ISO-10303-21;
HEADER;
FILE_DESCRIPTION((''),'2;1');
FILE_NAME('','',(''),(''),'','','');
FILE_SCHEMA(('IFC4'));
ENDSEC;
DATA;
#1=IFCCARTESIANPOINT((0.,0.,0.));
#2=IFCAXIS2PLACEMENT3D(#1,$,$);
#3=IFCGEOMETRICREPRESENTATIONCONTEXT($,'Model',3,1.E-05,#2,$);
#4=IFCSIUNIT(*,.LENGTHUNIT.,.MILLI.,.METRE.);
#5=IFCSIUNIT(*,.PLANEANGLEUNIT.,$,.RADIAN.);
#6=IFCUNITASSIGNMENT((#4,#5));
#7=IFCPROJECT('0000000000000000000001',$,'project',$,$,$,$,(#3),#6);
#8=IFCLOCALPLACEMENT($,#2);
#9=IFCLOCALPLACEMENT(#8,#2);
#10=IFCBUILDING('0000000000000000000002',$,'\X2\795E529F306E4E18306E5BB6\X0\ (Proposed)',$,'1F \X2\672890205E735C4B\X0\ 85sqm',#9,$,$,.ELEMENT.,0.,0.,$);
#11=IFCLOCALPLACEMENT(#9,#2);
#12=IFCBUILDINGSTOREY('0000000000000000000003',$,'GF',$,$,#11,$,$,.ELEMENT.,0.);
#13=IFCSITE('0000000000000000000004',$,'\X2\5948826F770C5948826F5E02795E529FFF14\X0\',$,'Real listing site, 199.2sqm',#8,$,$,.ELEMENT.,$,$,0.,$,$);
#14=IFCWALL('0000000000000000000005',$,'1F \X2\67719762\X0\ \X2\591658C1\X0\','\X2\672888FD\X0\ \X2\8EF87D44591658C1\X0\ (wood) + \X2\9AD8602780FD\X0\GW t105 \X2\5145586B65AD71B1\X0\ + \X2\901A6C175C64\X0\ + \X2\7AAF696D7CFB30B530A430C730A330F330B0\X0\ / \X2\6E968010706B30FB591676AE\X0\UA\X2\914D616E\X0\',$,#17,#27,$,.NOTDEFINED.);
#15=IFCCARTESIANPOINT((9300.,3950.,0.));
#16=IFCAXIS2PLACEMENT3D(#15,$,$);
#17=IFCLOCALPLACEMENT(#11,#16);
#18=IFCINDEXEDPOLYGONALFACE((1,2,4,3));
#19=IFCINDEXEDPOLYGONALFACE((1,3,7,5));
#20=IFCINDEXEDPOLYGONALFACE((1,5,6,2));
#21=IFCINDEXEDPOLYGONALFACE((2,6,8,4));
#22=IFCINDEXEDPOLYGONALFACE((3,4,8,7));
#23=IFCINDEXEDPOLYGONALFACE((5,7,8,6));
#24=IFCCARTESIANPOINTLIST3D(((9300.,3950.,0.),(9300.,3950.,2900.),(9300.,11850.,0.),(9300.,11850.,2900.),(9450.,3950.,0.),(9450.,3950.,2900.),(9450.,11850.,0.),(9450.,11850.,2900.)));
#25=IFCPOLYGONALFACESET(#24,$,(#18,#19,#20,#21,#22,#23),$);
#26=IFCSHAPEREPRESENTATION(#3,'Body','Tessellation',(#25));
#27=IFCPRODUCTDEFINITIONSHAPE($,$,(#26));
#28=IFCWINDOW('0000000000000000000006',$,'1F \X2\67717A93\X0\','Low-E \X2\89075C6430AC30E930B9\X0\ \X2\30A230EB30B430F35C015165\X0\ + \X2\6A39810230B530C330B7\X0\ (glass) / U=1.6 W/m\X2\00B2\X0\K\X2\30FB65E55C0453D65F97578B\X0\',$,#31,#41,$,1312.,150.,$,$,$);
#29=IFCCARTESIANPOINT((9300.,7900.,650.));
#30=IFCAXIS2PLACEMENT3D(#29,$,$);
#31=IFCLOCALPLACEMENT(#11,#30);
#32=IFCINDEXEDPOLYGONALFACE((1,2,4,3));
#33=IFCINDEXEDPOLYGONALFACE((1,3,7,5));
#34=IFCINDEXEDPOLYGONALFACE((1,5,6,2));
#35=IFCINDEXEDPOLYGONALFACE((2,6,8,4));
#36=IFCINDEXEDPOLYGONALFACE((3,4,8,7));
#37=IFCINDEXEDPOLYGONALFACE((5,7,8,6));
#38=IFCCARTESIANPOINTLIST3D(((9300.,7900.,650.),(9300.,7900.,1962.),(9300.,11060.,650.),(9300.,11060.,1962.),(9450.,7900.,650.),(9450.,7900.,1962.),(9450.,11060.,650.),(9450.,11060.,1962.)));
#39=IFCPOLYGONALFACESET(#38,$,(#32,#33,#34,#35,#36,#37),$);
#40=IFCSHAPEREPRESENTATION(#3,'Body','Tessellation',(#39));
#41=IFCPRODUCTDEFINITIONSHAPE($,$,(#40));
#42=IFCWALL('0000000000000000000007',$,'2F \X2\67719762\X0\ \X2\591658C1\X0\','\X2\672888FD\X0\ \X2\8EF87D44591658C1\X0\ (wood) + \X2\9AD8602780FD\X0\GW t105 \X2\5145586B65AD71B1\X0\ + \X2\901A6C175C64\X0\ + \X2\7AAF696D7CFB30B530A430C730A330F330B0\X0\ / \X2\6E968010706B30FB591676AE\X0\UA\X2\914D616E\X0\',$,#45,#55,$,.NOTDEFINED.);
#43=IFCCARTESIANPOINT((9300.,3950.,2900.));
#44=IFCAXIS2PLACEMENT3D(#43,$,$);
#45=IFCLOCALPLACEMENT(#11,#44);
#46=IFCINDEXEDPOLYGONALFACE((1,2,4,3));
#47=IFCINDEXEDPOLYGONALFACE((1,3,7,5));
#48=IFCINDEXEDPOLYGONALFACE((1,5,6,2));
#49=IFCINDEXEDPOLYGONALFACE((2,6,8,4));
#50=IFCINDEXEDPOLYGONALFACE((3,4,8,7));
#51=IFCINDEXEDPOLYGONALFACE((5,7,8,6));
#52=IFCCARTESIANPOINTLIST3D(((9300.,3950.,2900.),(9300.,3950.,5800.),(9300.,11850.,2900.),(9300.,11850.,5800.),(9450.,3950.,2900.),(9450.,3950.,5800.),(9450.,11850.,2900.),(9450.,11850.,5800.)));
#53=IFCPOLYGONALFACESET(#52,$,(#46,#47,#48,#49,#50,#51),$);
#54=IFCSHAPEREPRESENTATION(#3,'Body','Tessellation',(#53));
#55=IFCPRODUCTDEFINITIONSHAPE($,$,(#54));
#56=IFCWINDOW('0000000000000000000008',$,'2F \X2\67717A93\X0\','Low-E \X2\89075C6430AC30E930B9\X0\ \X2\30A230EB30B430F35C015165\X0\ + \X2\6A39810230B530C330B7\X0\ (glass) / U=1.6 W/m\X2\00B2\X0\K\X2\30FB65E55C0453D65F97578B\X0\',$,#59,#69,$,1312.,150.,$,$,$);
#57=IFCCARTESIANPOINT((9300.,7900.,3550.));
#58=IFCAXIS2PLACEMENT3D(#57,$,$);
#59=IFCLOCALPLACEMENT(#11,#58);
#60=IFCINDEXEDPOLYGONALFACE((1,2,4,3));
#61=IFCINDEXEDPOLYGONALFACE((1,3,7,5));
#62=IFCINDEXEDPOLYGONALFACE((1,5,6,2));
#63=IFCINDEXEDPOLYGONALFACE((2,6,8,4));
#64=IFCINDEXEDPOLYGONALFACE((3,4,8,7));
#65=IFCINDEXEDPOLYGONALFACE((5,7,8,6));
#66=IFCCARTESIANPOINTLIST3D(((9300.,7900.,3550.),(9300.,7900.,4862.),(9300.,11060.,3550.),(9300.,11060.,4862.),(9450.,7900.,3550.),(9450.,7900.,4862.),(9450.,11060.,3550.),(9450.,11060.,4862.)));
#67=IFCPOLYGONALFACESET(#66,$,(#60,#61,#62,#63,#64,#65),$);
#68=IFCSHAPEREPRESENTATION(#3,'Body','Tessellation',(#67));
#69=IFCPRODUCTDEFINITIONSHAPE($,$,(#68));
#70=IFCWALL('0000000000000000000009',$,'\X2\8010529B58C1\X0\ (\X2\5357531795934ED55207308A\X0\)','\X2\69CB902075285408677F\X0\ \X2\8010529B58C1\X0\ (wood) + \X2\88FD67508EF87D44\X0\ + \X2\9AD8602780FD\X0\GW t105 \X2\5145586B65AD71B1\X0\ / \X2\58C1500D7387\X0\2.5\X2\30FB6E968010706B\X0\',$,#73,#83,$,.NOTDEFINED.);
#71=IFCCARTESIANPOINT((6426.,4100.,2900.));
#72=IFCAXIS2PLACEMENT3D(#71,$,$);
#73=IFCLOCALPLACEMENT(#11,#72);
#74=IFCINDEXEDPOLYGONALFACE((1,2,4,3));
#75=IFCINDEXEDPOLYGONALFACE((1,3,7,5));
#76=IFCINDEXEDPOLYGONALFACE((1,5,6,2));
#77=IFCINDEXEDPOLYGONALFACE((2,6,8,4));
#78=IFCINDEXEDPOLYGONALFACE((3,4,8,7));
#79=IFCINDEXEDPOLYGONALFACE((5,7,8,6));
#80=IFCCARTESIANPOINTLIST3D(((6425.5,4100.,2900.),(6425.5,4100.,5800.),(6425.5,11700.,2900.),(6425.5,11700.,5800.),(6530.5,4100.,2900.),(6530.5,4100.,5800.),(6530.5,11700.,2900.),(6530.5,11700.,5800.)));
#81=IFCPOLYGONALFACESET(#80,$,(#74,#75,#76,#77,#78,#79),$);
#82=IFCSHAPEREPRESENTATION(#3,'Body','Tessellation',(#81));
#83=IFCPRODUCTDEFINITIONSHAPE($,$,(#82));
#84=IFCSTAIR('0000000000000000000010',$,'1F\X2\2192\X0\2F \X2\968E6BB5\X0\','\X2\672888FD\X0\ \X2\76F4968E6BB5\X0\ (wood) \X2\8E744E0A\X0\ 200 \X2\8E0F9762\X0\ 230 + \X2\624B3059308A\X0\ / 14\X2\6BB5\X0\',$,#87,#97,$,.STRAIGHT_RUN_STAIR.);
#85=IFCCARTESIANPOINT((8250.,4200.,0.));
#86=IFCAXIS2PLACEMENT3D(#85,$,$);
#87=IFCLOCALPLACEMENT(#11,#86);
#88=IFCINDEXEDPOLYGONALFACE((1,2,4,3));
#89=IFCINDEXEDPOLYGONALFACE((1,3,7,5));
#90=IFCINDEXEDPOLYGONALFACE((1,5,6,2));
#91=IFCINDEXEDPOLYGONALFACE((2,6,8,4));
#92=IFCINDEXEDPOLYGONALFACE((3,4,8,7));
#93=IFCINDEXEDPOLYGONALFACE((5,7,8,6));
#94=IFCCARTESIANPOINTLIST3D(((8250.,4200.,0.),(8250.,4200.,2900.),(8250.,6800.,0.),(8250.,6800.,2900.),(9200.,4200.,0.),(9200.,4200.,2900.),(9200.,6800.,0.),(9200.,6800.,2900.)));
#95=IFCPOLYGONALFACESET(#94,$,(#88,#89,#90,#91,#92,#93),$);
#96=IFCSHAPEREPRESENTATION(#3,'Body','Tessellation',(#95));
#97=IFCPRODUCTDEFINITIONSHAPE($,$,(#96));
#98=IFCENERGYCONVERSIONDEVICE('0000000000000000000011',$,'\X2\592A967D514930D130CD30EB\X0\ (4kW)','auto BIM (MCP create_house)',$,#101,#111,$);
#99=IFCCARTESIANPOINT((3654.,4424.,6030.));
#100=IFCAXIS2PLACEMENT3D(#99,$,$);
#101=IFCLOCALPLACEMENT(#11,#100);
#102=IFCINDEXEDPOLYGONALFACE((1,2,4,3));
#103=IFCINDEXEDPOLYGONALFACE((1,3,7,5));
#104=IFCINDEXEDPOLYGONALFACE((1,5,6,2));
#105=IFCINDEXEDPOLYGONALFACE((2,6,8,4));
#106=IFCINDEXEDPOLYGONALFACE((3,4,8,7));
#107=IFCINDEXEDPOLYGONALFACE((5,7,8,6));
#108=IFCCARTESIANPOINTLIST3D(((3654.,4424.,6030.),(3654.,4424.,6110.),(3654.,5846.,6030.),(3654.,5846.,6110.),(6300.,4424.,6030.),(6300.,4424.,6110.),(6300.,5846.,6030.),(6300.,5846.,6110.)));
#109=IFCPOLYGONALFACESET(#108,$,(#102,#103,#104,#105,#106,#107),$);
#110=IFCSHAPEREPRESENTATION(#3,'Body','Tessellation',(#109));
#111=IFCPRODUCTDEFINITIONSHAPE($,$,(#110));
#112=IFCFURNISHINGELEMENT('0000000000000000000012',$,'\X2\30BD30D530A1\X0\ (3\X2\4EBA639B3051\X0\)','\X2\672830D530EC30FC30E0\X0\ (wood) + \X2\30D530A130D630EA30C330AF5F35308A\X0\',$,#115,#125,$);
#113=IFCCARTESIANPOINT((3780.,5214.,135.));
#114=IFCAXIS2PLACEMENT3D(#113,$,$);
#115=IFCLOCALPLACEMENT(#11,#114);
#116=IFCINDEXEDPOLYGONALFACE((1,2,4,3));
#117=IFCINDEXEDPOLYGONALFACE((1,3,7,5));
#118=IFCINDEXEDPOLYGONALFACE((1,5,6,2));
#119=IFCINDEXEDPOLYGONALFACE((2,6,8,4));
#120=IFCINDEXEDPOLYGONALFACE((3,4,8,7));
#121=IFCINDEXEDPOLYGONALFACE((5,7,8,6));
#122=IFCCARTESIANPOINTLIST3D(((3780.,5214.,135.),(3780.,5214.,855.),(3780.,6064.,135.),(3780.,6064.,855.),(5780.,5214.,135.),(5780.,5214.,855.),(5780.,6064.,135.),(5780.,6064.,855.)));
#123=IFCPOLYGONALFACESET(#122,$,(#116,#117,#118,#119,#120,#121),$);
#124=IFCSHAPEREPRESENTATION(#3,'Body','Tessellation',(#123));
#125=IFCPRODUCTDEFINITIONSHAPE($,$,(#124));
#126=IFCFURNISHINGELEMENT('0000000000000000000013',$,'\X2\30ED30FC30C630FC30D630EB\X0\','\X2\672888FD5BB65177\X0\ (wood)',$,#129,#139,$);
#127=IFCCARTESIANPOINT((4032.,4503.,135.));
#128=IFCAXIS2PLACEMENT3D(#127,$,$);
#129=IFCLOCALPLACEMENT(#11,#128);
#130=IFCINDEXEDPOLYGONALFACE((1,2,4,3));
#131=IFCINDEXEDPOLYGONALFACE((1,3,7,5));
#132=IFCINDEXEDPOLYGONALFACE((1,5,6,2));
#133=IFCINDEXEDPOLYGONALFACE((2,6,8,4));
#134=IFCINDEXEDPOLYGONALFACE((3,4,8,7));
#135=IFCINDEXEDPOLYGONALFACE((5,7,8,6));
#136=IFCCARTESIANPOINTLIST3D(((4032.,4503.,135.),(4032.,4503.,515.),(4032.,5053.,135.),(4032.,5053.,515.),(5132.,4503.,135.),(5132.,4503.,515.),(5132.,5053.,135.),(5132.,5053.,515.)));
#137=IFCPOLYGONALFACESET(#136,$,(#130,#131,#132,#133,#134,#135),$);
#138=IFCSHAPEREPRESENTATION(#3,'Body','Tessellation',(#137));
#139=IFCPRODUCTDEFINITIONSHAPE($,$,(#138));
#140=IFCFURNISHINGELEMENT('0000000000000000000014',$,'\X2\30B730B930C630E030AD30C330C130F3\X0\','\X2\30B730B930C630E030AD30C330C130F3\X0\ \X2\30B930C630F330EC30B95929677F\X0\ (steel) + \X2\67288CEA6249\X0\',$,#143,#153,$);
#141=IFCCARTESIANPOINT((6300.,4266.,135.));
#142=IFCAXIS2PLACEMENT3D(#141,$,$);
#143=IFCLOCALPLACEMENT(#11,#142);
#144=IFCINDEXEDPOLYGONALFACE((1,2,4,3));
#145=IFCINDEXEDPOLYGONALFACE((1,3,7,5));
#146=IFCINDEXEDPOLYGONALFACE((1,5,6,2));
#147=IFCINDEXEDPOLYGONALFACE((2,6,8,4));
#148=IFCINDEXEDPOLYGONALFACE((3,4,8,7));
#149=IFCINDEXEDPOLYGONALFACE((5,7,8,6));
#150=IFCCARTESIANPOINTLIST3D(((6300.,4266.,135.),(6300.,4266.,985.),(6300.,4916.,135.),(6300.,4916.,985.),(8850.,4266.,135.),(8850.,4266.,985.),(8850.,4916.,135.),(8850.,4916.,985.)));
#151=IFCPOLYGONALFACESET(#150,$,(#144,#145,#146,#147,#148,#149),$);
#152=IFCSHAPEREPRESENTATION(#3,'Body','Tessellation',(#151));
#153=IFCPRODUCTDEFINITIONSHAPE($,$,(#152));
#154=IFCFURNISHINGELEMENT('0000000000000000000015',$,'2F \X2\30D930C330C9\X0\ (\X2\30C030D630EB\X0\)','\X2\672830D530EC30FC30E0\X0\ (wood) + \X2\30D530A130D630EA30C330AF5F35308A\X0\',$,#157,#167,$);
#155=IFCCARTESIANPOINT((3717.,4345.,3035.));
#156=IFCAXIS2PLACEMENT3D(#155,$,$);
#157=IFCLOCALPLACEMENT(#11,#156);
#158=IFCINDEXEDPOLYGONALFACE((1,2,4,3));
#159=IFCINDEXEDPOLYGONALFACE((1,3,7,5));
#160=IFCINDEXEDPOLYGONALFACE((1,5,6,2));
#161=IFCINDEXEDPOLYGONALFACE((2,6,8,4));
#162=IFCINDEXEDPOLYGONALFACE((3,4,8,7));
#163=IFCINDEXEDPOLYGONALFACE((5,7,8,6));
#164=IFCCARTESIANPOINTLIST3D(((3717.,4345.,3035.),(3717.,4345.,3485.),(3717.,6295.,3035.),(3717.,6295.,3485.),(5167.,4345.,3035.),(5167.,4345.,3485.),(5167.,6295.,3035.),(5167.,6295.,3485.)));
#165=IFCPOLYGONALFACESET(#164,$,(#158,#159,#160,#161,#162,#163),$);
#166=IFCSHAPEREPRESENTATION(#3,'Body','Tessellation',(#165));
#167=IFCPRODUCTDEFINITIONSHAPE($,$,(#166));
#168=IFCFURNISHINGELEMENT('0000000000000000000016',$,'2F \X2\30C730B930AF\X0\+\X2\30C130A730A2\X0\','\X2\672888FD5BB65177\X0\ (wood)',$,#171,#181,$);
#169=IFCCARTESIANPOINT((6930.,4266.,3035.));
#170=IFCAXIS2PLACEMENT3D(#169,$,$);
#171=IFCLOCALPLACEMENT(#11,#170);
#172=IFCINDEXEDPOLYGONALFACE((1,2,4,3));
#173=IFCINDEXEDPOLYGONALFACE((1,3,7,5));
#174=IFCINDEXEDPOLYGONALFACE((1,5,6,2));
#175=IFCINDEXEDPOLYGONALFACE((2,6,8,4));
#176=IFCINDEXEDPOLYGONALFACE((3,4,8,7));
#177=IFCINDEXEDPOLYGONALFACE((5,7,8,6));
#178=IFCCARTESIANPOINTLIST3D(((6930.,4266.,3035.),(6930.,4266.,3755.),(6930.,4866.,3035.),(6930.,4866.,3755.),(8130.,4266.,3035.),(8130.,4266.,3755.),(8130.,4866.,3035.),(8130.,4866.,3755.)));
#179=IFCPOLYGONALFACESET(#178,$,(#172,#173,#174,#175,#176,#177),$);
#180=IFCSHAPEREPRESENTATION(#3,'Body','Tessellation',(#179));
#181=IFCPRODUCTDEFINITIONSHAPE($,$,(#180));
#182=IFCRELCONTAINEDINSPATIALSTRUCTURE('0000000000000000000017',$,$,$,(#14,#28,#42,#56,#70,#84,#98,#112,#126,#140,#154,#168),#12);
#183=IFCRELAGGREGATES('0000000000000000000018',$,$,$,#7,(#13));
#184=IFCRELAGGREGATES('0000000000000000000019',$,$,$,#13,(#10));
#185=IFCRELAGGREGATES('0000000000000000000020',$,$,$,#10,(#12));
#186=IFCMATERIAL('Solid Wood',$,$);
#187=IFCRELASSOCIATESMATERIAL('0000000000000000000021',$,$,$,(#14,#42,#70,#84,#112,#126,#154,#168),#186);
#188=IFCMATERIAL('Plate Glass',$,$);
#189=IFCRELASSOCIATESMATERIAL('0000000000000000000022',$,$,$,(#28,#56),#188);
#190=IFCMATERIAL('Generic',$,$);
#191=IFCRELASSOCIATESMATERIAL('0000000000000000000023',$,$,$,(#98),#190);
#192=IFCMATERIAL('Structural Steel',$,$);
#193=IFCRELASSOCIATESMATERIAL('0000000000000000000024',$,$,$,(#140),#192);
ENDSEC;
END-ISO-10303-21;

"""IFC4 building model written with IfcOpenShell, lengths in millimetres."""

from ifc_helpers import new_model, si_unit, frame, frame_2d, origin, place, context, project, spatial, rectangle, extrude, material, element, fill, save


model = new_model("IFC4")

# Units and contexts
model_context = context("Model", 3, precision=1e-05, world=origin())
ifc_project = project(units=[si_unit("LENGTHUNIT", "METRE", prefix="MILLI"), si_unit("PLANEANGLEUNIT", "RADIAN")], contexts=[model_context])

# Site, building, storey
site_placement = place(None, origin())
site = spatial("IfcSite", under=ifc_project, at=site_placement, Name="奈良県奈良市神功４", ObjectType="Real listing site, 199.2sqm", CompositionType="ELEMENT", RefElevation=0.0)
building_placement = place(site_placement, origin())
building = spatial("IfcBuilding", under=site, at=building_placement, Name="神功の丘の家 (Proposed)", ObjectType="1F 木造平屋 85sqm", CompositionType="ELEMENT", ElevationOfRefHeight=0.0, ElevationOfTerrain=0.0)
storey_placement = place(building_placement, origin())
storey = spatial("IfcBuildingStorey", under=building, at=storey_placement, Name="GF", CompositionType="ELEMENT", Elevation=0.0)

# Wall, opening, window
ifc_material_1 = material(Name="Solid Wood")
wall_1_placement = place(storey_placement, frame((9300.0, 3950.0, 0.0)))
wall_1 = element("IfcWall", 1, at=wall_1_placement, inside=storey, material=ifc_material_1, Name="1F 東面 外壁", Description="木製 軸組外壁 (wood) + 高性能GW t105 充填断熱 + 通気層 + 窯業系サイディング / 準耐火・外皮UA配慮", PredefinedType="NOTDEFINED", context=model_context, shape_type="SweptSolid", body=[
    extrude(rectangle(XDim=150.0, YDim=7900.0, at=frame_2d((75.0, 3950.0))), frame((9300.0, 3950.0, 0.0)), (0.0, 0.0, 1.0), 2900.0),
])
opening_1_placement = place(storey_placement, frame((9300.0, 7900.0, 650.0)))
opening_1 = element("IfcOpeningElement", 2, at=opening_1_placement, cuts=wall_1, PredefinedType="NOTDEFINED", context=model_context, shape_type="SweptSolid", body=[
    extrude(rectangle(XDim=150.0, YDim=3160.0, at=frame_2d((75.0, 1580.0))), frame((9300.0, 7900.0, 650.0)), (0.0, 0.0, 1.0), 1312.0),
])
ifc_material_2 = material(Name="Plate Glass")
window_1_placement = place(storey_placement, frame((9300.0, 7900.0, 650.0)))
window_1 = element("IfcWindow", 3, at=window_1_placement, inside=storey, material=ifc_material_2, Name="1F 東窓", Description="Low-E 複層ガラス アルゴン封入 + 樹脂サッシ (glass) / U=1.6 W/m²K・日射取得型", OverallHeight=1312.0, OverallWidth=150.0, context=model_context, shape_type="SweptSolid", body=[
    extrude(rectangle(XDim=150.0, YDim=3160.0, at=frame_2d((75.0, 1580.0))), frame((9300.0, 7900.0, 650.0)), (0.0, 0.0, 1.0), 1312.0),
])
fill(opening_1, window_1)

# Wall, opening, window
wall_2_placement = place(storey_placement, frame((9300.0, 3950.0, 2900.0)))
wall_2 = element("IfcWall", 4, at=wall_2_placement, inside=storey, material=ifc_material_1, Name="2F 東面 外壁", Description="木製 軸組外壁 (wood) + 高性能GW t105 充填断熱 + 通気層 + 窯業系サイディング / 準耐火・外皮UA配慮", PredefinedType="NOTDEFINED", context=model_context, shape_type="SweptSolid", body=[
    extrude(rectangle(XDim=150.0, YDim=7900.0, at=frame_2d((75.0, 3950.0))), frame((9300.0, 3950.0, 2900.0)), (0.0, 0.0, 1.0), 2900.0),
])
opening_2_placement = place(storey_placement, frame((9300.0, 7900.0, 3550.0)))
opening_2 = element("IfcOpeningElement", 5, at=opening_2_placement, cuts=wall_2, PredefinedType="NOTDEFINED", context=model_context, shape_type="SweptSolid", body=[
    extrude(rectangle(XDim=150.0, YDim=3160.0, at=frame_2d((75.0, 1580.0))), frame((9300.0, 7900.0, 3550.0)), (0.0, 0.0, 1.0), 1312.0),
])
window_2_placement = place(storey_placement, frame((9300.0, 7900.0, 3550.0)))
window_2 = element("IfcWindow", 6, at=window_2_placement, inside=storey, material=ifc_material_2, Name="2F 東窓", Description="Low-E 複層ガラス アルゴン封入 + 樹脂サッシ (glass) / U=1.6 W/m²K・日射取得型", OverallHeight=1312.0, OverallWidth=150.0, context=model_context, shape_type="SweptSolid", body=[
    extrude(rectangle(XDim=150.0, YDim=3160.0, at=frame_2d((75.0, 1580.0))), frame((9300.0, 7900.0, 3550.0)), (0.0, 0.0, 1.0), 1312.0),
])
fill(opening_2, window_2)

# Wall
wall_3_placement = place(storey_placement, frame((6426.0, 4100.0, 2900.0)))
element("IfcWall", 7, at=wall_3_placement, inside=storey, material=ifc_material_1, Name="耐力壁 (南北間仕切り)", Description="構造用合板 耐力壁 (wood) + 製材軸組 + 高性能GW t105 充填断熱 / 壁倍率2.5・準耐火", PredefinedType="NOTDEFINED", context=model_context, shape_type="SweptSolid", body=[
    extrude(rectangle(XDim=105.0, YDim=7600.0, at=frame_2d((52.0, 3800.0))), frame((6426.0, 4100.0, 2900.0)), (0.0, 0.0, 1.0), 2900.0),
])

# Stair
stair_placement = place(storey_placement, frame((8250.0, 4200.0, 0.0)))
element("IfcStair", 8, at=stair_placement, inside=storey, material=ifc_material_1, Name="1F→2F 階段", Description="木製 直階段 (wood) 蹴上 200 踏面 230 + 手すり / 14段", PredefinedType="STRAIGHT_RUN_STAIR", context=model_context, shape_type="SweptSolid", body=[
    extrude(rectangle(XDim=950.0, YDim=2600.0, at=frame_2d((475.0, 1300.0))), frame((8250.0, 4200.0, 0.0)), (0.0, 0.0, 1.0), 2900.0),
])

# Energy conversion device
ifc_material_3 = material(Name="Generic")
energy_conversion_device_placement = place(storey_placement, frame((3654.0, 4424.0, 6030.0)))
element("IfcEnergyConversionDevice", 9, at=energy_conversion_device_placement, inside=storey, material=ifc_material_3, Name="太陽光パネル (4kW)", Description="auto BIM (MCP create_house)", context=model_context, shape_type="SweptSolid", body=[
    extrude(rectangle(XDim=2646.0, YDim=1422.0, at=frame_2d((1323.0, 711.0))), frame((3654.0, 4424.0, 6030.0)), (0.0, 0.0, 1.0), 80.0),
])

# Furnishing elements
furnishing_1_placement = place(storey_placement, frame((3780.0, 5214.0, 135.0)))
element("IfcFurnishingElement", 10, at=furnishing_1_placement, inside=storey, material=ifc_material_1, Name="ソファ (3人掛け)", Description="木フレーム (wood) + ファブリック張り", context=model_context, shape_type="SweptSolid", body=[
    extrude(rectangle(XDim=2000.0, YDim=850.0, at=frame_2d((1000.0, 425.0))), frame((3780.0, 5214.0, 135.0)), (0.0, 0.0, 1.0), 720.0),
])
furnishing_2_placement = place(storey_placement, frame((4032.0, 4503.0, 135.0)))
element("IfcFurnishingElement", 11, at=furnishing_2_placement, inside=storey, material=ifc_material_1, Name="ローテーブル", Description="木製家具 (wood)", context=model_context, shape_type="SweptSolid", body=[
    extrude(rectangle(XDim=1100.0, YDim=550.0, at=frame_2d((550.0, 275.0))), frame((4032.0, 4503.0, 135.0)), (0.0, 0.0, 1.0), 380.0),
])
ifc_material_4 = material(Name="Structural Steel")
furnishing_3_placement = place(storey_placement, frame((6300.0, 4266.0, 135.0)))
element("IfcFurnishingElement", 12, at=furnishing_3_placement, inside=storey, material=ifc_material_4, Name="システムキッチン", Description="システムキッチン ステンレス天板 (steel) + 木質扉", context=model_context, shape_type="SweptSolid", body=[
    extrude(rectangle(XDim=2550.0, YDim=650.0, at=frame_2d((1275.0, 325.0))), frame((6300.0, 4266.0, 135.0)), (0.0, 0.0, 1.0), 850.0),
])
furnishing_4_placement = place(storey_placement, frame((3717.0, 4345.0, 3035.0)))
element("IfcFurnishingElement", 13, at=furnishing_4_placement, inside=storey, material=ifc_material_1, Name="2F ベッド (ダブル)", Description="木フレーム (wood) + ファブリック張り", context=model_context, shape_type="SweptSolid", body=[
    extrude(rectangle(XDim=1450.0, YDim=1950.0, at=frame_2d((725.0, 975.0))), frame((3717.0, 4345.0, 3035.0)), (0.0, 0.0, 1.0), 450.0),
])
furnishing_5_placement = place(storey_placement, frame((6930.0, 4266.0, 3035.0)))
element("IfcFurnishingElement", 14, at=furnishing_5_placement, inside=storey, material=ifc_material_1, Name="2F デスク+チェア", Description="木製家具 (wood)", context=model_context, shape_type="SweptSolid", body=[
    extrude(rectangle(XDim=1200.0, YDim=600.0, at=frame_2d((600.0, 300.0))), frame((6930.0, 4266.0, 3035.0)), (0.0, 0.0, 1.0), 720.0),
])

save(model, "model.ifc")
